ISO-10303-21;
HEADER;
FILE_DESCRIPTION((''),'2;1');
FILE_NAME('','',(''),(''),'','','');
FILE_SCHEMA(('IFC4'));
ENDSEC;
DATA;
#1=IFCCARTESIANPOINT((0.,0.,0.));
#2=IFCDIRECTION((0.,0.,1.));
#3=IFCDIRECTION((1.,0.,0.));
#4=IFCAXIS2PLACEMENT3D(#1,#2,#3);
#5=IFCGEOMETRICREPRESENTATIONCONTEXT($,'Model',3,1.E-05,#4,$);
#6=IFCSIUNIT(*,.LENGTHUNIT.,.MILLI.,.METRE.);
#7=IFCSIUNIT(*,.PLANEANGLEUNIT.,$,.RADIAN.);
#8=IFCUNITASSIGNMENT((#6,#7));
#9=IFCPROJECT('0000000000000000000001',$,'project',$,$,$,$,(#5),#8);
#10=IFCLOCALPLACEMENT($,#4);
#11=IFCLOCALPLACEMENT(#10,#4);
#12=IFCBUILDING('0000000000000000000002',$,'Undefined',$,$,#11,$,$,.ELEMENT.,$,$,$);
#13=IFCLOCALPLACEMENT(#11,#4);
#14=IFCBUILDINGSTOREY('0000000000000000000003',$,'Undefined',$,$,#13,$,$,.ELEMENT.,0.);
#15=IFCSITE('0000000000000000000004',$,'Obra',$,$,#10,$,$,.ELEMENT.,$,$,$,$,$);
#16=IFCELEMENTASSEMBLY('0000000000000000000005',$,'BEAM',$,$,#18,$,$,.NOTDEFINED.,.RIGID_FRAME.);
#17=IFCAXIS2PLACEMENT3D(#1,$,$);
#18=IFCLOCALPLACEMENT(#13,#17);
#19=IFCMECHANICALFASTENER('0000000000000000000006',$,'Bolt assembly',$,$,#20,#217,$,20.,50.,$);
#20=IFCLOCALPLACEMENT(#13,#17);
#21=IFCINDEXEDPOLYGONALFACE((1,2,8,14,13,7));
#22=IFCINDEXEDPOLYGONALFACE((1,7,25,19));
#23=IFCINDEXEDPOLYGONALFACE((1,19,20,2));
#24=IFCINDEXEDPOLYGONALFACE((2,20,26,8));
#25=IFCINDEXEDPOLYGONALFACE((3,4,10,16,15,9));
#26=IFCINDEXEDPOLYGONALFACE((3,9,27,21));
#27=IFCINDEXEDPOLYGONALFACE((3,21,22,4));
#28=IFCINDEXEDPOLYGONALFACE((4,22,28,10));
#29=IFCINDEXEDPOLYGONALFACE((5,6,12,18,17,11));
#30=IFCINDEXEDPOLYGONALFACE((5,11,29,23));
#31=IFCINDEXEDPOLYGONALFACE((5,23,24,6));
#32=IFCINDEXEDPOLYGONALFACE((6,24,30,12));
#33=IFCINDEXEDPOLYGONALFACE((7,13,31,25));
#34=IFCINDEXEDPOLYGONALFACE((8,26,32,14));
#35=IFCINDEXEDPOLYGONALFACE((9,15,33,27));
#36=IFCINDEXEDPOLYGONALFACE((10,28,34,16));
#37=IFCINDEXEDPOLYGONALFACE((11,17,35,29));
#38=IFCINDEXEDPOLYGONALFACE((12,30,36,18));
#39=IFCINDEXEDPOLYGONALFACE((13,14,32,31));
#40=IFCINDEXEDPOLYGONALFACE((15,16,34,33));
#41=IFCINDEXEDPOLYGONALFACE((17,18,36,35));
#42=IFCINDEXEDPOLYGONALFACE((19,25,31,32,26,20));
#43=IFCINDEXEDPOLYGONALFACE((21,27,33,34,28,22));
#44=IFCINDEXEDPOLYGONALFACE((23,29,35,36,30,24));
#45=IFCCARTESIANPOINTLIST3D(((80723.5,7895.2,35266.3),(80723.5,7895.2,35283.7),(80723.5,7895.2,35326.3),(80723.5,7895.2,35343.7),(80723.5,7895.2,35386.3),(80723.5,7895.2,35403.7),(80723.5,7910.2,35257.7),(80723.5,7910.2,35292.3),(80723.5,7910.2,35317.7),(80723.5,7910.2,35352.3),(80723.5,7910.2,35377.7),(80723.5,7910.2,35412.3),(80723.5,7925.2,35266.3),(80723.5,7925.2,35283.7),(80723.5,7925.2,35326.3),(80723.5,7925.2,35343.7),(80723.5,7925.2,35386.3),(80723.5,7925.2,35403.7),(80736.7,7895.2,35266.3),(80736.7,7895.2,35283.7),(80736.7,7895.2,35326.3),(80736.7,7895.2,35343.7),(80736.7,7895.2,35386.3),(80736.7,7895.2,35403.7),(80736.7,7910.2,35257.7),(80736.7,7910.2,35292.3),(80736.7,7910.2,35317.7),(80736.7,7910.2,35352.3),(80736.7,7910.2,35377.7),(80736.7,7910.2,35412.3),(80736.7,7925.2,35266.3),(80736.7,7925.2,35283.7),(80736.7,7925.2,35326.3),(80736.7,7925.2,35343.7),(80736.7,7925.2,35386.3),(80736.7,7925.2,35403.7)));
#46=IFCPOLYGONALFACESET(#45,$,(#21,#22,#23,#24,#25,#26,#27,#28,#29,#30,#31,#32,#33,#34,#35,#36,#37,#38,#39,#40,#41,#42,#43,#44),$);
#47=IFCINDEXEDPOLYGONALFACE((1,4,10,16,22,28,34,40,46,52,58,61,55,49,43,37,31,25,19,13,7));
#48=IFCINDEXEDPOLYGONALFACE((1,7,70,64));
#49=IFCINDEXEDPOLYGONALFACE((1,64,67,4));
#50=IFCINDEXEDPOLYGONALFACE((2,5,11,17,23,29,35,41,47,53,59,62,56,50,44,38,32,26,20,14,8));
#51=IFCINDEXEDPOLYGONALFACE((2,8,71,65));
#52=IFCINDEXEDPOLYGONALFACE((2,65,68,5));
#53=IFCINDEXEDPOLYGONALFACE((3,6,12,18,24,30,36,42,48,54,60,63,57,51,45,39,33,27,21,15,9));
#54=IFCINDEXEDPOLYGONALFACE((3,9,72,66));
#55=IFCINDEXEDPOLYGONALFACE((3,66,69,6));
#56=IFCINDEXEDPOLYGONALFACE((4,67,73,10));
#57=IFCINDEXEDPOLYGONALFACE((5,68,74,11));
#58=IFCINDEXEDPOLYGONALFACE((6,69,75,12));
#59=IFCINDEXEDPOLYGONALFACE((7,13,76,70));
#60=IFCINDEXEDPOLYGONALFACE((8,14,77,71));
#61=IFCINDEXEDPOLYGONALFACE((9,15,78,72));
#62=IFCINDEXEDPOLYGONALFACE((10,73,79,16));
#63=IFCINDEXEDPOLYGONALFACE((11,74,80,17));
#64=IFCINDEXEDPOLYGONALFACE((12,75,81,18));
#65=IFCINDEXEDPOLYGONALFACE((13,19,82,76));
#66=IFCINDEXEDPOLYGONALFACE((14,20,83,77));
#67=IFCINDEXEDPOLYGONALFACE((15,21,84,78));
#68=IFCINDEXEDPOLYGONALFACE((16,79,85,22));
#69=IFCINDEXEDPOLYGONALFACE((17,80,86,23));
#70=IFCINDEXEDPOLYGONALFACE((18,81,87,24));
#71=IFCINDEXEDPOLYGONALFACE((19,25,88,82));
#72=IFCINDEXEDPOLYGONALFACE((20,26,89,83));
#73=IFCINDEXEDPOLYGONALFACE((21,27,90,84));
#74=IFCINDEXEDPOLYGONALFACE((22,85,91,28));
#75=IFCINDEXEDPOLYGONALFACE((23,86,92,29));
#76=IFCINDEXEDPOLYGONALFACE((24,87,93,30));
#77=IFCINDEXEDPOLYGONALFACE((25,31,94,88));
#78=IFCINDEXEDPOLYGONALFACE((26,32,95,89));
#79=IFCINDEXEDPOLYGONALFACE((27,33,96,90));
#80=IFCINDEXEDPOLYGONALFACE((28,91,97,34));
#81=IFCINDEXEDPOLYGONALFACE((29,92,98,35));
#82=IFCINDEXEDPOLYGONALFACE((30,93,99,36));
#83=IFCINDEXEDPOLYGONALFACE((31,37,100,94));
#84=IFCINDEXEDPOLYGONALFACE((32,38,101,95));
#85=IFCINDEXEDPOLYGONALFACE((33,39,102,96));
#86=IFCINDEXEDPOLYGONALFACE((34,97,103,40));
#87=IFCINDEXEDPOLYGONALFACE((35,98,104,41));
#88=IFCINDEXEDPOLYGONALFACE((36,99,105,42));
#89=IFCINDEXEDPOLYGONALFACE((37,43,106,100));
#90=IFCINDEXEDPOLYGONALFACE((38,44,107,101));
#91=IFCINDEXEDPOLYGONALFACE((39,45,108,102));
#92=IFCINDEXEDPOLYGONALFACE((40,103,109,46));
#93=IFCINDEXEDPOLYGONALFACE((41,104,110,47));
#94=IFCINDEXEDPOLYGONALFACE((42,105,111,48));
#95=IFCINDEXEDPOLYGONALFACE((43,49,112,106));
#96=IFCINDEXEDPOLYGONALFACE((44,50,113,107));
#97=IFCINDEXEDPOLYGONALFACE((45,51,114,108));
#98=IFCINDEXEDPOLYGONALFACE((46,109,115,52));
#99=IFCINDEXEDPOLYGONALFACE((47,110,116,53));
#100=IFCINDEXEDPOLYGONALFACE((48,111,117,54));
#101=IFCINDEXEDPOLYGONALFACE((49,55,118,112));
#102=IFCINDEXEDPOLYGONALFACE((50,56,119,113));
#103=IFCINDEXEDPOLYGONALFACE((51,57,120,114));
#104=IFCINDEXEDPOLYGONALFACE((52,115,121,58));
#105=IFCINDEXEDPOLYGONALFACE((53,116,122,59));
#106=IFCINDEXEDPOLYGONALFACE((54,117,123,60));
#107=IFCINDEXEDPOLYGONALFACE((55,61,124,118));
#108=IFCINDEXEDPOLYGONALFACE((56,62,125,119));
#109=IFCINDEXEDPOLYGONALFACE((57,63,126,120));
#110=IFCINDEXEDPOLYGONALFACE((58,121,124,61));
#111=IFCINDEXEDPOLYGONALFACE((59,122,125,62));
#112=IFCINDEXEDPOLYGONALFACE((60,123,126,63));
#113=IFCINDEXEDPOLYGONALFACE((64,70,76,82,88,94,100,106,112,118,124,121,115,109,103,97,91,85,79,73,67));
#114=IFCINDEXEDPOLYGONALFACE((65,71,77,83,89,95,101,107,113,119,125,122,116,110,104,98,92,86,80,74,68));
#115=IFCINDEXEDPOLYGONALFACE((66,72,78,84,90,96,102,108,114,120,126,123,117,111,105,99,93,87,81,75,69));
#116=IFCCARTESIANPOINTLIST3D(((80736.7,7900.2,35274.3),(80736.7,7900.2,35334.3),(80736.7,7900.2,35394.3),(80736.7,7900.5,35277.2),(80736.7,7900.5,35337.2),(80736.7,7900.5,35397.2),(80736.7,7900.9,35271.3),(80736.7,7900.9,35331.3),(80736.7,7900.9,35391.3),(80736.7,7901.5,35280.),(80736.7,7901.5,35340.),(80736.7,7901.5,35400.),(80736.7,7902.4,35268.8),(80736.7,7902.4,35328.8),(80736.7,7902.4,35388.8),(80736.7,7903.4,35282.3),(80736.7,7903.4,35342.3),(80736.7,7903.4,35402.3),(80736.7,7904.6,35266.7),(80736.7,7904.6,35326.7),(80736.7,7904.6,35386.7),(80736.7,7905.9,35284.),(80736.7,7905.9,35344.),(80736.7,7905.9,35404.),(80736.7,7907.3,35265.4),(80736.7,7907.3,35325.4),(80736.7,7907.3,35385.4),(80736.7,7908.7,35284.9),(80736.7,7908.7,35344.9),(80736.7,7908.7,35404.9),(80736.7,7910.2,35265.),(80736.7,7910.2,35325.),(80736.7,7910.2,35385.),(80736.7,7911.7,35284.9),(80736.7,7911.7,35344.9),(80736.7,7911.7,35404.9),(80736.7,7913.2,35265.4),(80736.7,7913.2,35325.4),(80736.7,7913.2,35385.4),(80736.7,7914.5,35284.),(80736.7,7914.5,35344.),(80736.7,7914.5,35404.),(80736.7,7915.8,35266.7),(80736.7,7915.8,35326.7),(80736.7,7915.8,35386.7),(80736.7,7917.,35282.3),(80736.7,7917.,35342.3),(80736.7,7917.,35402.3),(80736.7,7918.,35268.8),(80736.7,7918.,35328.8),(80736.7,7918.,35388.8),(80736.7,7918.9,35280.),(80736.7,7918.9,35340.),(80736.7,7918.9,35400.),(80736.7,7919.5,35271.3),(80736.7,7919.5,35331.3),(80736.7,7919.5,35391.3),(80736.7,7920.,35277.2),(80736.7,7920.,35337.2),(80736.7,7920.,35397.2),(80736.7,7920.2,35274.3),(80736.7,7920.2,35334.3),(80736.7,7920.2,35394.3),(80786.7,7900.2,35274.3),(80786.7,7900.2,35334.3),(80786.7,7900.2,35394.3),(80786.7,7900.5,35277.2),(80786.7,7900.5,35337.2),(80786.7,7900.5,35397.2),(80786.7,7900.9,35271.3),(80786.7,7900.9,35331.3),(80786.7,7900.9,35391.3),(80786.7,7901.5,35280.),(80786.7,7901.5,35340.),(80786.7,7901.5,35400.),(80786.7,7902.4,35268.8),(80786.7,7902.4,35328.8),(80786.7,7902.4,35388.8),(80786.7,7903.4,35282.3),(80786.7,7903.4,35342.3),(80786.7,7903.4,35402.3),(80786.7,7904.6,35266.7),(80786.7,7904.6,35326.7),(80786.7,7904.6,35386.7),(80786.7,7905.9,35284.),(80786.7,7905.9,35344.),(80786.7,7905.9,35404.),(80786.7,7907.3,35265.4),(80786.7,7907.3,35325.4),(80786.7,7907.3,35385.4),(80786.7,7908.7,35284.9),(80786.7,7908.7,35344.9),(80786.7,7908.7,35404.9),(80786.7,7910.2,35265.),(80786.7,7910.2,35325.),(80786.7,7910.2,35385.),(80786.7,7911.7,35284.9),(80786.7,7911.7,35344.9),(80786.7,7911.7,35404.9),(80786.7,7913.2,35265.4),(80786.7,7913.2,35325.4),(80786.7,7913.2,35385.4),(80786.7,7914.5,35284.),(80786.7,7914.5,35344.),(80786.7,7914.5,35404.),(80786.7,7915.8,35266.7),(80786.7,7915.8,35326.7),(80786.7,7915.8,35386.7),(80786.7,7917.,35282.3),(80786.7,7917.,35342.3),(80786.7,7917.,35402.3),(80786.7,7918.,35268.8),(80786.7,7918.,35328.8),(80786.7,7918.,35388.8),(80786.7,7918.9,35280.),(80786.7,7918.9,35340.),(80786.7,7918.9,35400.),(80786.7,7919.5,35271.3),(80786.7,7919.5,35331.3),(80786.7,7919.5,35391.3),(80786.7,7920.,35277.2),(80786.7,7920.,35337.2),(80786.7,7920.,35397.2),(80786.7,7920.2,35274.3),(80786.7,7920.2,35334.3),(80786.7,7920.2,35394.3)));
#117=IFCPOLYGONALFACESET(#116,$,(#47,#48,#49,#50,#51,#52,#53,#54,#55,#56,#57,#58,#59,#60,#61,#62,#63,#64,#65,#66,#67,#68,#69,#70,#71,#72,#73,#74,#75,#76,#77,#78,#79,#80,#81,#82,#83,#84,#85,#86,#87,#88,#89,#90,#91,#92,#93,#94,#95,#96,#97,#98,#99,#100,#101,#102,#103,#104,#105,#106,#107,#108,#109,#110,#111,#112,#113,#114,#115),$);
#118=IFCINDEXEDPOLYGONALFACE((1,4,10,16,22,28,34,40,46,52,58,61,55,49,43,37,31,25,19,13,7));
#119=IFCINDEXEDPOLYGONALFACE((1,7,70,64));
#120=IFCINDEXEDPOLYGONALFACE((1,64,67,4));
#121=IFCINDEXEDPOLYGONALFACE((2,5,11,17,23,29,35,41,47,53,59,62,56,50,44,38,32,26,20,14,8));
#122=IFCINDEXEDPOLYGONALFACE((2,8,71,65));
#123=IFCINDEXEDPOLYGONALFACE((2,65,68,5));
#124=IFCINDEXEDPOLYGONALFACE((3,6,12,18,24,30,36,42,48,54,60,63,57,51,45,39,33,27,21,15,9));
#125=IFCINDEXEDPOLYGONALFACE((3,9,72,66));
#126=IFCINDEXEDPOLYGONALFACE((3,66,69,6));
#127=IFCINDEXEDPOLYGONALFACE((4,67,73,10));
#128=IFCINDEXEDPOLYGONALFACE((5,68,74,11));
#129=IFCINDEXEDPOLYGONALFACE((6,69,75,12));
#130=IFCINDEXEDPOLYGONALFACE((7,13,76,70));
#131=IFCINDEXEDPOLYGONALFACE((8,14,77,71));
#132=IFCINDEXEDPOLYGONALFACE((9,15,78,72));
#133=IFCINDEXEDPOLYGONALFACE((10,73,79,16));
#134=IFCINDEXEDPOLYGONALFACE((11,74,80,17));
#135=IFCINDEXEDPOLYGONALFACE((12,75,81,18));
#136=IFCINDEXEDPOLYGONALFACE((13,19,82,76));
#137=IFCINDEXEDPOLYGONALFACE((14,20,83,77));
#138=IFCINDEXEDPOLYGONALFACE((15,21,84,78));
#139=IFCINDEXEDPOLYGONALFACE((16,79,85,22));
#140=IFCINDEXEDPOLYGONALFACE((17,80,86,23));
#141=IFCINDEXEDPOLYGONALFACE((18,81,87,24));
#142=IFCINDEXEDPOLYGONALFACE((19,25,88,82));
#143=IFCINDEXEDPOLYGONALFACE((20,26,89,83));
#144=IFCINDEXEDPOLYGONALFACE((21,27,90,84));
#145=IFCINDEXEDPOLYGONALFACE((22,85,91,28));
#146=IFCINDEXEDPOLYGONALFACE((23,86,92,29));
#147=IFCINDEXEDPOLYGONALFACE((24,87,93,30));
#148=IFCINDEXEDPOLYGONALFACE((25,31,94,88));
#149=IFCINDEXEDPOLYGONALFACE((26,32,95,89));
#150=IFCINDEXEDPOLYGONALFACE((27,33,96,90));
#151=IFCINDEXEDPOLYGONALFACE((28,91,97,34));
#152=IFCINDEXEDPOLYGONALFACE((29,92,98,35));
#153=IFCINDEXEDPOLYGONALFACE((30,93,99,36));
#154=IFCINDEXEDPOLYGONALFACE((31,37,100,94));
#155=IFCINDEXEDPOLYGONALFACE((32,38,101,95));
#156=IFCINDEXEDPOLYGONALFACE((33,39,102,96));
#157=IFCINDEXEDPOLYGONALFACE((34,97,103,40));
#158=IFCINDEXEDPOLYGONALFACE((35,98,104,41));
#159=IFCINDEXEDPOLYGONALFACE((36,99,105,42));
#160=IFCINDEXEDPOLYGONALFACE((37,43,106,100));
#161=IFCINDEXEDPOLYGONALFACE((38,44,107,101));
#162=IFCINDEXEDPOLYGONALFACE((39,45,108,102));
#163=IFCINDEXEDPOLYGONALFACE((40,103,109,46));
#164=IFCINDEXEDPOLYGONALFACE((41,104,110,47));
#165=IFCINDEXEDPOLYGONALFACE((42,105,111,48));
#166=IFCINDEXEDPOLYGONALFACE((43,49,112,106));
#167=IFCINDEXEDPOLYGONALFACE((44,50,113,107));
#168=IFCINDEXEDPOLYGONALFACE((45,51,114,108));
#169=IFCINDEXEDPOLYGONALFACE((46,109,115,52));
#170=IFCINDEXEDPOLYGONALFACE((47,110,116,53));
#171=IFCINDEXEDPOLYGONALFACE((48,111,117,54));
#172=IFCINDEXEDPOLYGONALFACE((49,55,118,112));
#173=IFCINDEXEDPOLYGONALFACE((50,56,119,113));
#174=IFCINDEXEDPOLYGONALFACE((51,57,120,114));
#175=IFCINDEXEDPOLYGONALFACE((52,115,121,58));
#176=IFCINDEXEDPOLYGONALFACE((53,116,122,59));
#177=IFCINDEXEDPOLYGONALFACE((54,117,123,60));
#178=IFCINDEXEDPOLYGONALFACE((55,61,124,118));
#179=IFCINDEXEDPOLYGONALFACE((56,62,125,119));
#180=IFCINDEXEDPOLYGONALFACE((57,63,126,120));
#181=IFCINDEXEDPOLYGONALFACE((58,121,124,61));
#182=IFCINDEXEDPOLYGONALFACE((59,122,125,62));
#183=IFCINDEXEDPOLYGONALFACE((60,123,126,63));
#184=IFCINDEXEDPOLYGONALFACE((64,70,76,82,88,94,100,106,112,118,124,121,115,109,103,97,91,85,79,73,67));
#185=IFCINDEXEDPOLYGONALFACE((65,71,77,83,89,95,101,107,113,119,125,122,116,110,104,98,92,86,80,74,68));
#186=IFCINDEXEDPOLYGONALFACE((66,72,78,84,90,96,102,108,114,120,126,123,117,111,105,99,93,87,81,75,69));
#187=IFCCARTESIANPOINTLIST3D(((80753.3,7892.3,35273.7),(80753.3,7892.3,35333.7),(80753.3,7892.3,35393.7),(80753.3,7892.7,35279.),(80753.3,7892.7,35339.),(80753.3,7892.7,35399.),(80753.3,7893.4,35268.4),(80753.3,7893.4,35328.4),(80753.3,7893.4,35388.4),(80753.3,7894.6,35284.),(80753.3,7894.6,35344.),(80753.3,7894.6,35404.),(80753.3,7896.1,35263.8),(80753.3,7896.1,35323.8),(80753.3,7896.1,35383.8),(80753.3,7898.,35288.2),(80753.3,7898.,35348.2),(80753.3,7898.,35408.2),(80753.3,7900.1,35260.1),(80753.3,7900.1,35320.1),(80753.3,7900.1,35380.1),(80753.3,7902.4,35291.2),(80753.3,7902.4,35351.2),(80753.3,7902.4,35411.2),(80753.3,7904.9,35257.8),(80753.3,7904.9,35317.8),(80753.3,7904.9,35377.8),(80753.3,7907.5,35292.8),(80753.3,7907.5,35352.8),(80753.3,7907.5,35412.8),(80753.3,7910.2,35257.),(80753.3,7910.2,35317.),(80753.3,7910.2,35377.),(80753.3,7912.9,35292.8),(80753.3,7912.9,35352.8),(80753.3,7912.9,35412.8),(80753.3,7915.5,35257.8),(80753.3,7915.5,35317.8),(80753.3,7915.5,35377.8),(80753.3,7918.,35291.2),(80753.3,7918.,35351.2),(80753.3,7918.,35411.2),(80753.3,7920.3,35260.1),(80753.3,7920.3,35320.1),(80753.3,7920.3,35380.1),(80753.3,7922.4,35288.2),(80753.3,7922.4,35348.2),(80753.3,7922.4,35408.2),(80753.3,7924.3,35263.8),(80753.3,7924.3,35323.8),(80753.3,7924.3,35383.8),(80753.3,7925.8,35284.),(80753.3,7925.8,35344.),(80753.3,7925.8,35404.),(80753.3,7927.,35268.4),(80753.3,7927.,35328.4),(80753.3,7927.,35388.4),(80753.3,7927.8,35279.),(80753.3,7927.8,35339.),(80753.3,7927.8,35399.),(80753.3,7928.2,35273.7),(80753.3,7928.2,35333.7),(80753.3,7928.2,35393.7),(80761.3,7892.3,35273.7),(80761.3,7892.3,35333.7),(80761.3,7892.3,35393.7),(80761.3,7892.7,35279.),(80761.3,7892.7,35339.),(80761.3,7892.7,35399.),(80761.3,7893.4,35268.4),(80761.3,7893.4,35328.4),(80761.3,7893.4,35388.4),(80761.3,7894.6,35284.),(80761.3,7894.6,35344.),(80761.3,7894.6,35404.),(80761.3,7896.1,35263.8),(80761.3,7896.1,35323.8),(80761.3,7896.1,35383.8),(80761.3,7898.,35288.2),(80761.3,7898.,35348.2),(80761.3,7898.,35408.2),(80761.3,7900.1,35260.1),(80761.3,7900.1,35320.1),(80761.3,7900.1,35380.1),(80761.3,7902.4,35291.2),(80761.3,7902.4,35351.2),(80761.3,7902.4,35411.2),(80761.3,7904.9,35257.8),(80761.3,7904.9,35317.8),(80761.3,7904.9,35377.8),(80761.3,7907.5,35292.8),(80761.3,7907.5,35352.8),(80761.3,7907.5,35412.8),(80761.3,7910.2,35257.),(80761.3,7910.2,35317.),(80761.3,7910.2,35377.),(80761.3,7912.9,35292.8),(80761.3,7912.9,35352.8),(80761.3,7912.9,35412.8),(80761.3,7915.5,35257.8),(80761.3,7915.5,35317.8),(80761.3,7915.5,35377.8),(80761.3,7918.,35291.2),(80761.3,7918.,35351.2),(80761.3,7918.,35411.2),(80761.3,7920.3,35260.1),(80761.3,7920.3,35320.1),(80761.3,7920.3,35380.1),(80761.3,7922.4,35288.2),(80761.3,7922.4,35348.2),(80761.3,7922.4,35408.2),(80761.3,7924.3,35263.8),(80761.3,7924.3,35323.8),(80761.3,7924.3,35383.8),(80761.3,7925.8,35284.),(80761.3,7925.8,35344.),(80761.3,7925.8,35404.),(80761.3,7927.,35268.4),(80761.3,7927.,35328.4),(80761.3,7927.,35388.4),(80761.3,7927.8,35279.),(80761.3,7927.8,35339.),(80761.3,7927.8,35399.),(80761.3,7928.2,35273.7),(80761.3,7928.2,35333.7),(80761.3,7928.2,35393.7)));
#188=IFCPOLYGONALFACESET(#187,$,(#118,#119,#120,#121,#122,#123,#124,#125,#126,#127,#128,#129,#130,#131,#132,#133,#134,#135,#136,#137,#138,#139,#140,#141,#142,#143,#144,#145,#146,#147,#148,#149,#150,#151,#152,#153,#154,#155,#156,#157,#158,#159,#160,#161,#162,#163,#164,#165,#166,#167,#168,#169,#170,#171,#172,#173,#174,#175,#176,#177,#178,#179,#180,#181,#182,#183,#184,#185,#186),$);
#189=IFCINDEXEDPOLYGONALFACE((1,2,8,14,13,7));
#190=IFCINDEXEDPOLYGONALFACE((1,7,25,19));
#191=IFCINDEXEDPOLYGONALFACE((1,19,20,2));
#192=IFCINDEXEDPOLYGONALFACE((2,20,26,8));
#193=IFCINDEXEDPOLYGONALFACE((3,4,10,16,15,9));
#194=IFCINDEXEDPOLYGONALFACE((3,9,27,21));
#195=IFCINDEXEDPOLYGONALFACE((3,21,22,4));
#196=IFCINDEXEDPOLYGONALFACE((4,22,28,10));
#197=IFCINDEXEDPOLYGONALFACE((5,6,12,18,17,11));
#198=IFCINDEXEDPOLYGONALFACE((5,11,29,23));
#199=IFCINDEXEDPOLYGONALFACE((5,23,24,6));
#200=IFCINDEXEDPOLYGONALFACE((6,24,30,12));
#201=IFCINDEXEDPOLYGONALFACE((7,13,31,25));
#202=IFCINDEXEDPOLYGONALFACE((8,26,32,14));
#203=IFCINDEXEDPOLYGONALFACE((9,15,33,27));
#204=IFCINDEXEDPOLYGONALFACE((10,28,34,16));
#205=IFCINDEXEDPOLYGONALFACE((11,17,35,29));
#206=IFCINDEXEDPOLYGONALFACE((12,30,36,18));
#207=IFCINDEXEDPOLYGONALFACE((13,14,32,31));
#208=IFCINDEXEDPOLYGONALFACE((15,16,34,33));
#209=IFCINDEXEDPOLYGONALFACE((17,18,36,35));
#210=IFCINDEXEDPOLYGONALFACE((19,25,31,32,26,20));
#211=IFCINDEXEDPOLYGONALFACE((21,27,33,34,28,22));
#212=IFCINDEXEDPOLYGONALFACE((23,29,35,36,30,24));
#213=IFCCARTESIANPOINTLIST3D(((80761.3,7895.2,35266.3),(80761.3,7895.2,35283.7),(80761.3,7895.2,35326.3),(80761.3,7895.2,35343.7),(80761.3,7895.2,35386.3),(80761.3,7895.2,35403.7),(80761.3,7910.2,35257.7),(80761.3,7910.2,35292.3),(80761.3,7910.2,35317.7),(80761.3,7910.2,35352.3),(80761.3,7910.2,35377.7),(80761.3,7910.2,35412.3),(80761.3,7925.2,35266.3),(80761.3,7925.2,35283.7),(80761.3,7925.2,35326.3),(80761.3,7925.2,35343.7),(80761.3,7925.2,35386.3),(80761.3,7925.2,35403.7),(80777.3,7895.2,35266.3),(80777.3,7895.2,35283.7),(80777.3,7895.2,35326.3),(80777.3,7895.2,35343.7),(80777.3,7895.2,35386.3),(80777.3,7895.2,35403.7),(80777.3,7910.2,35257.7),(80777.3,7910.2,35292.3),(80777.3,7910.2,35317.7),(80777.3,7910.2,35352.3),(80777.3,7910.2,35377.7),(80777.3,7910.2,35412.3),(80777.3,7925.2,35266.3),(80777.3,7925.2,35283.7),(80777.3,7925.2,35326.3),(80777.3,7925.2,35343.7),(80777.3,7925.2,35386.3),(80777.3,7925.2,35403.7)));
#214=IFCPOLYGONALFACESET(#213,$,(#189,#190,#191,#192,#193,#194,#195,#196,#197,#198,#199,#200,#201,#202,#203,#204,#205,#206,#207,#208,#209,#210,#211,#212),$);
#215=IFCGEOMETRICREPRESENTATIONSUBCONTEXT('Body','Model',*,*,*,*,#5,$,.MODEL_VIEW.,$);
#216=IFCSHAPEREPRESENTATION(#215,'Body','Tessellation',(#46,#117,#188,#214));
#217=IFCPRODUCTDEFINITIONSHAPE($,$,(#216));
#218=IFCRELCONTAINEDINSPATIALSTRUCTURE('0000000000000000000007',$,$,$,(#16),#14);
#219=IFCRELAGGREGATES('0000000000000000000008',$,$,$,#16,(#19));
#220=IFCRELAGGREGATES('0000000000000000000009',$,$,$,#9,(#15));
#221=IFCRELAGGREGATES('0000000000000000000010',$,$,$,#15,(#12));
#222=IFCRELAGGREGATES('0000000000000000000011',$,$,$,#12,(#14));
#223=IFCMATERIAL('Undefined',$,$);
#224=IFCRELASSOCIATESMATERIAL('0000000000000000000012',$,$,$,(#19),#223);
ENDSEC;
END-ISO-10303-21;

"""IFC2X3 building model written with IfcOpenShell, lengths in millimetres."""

from ifc_helpers import new_model, si_unit, frame, origin_with_axes, origin_2d_with_axis, place, context, subcontext, project, spatial, polyline, circle, outline, extrude, source, transform, mapped, material, element, aggregate, save


model = new_model("IFC2X3")

# Units and contexts
model_context = context("Model", 3, precision=1e-05, world=origin_with_axes())
body_context = subcontext(model_context, "Body", "Model", "MODEL_VIEW")
ifc_project = project(units=[si_unit("LENGTHUNIT", "METRE", prefix="MILLI"), si_unit("PLANEANGLEUNIT", "RADIAN")], contexts=[model_context])

# Site, building, storey
site_placement = place(None, origin_with_axes())
site = spatial("IfcSite", under=ifc_project, at=site_placement, Name="Obra", CompositionType="ELEMENT")
building_placement = place(site_placement, origin_with_axes())
building = spatial("IfcBuilding", under=site, at=building_placement, Name="Undefined", CompositionType="ELEMENT")
storey_placement = place(building_placement, origin_with_axes())
storey = spatial("IfcBuildingStorey", under=building, at=storey_placement, Name="Undefined", CompositionType="ELEMENT", Elevation=0.0)

# Element assembly
assembly_1_placement = place(storey_placement, origin_with_axes())
assembly_1 = element("IfcElementAssembly", 1, at=assembly_1_placement, inside=storey, Name="BEAM", AssemblyPlace="NOTDEFINED", PredefinedType="RIGID_FRAME")
ifc_material_1 = material(Name="Undefined")

# Mechanical fastener
shared_shape_1 = source(origin_with_axes(), body_context, "Body", "SweptSolid", [
    extrude(outline(polyline([(17.3, 0.0), (8.7, 15.0), (-8.7, 15.0), (-17.3, 0.0), (-8.7, -15.0), (8.7, -15.0), (17.3, 0.0)])), frame((0.0, -26.5, 0.0), z_axis=(0.0, 1.0, 0.0), x_axis=(1.0, 0.0, 0.0)), (0.0, 0.0, 1.0), 13.2),
    extrude(circle(Radius=10.0, at=origin_2d_with_axis()), frame((0.0, -13.3, 0.0), z_axis=(0.0, 1.0, 0.0), x_axis=(1.0, 0.0, 0.0)), (0.0, 0.0, 1.0), 50.0),
    extrude(circle(Radius=18.0, at=origin_2d_with_axis()), frame((0.0, 3.3, 0.0), z_axis=(0.0, 1.0, 0.0), x_axis=(1.0, 0.0, 0.0)), (0.0, 0.0, 1.0), 8.0),
    extrude(outline(polyline([(17.3, 0.0), (8.7, 15.0), (-8.7, 15.0), (-17.3, 0.0), (-8.7, -15.0), (8.7, -15.0), (17.3, 0.0)])), frame((0.0, 11.3, 0.0), z_axis=(0.0, 1.0, 0.0), x_axis=(1.0, 0.0, 0.0)), (0.0, 0.0, 1.0), 16.0),
])
mechanical_fastener_1_placement = place(assembly_1_placement, frame((80750.0, 7960.2, 35435.0), z_axis=(0.0, -1.0, 0.0), x_axis=(0.0, 0.0, -1.0)))
mechanical_fastener_1 = element("IfcMechanicalFastener", 2, at=mechanical_fastener_1_placement, material=ifc_material_1, Name="Bolt assembly", NominalDiameter=20.0, NominalLength=50.0, context=body_context, shape_type="MappedRepresentation", body=[
    mapped(shared_shape_1, transform((40.0, 0.0, 50.0))),
    mapped(shared_shape_1, transform((100.0, 0.0, 50.0))),
    mapped(shared_shape_1, transform((160.0, 0.0, 50.0))),
])
aggregate(assembly_1, [mechanical_fastener_1])

save(model, "model.ifc")
